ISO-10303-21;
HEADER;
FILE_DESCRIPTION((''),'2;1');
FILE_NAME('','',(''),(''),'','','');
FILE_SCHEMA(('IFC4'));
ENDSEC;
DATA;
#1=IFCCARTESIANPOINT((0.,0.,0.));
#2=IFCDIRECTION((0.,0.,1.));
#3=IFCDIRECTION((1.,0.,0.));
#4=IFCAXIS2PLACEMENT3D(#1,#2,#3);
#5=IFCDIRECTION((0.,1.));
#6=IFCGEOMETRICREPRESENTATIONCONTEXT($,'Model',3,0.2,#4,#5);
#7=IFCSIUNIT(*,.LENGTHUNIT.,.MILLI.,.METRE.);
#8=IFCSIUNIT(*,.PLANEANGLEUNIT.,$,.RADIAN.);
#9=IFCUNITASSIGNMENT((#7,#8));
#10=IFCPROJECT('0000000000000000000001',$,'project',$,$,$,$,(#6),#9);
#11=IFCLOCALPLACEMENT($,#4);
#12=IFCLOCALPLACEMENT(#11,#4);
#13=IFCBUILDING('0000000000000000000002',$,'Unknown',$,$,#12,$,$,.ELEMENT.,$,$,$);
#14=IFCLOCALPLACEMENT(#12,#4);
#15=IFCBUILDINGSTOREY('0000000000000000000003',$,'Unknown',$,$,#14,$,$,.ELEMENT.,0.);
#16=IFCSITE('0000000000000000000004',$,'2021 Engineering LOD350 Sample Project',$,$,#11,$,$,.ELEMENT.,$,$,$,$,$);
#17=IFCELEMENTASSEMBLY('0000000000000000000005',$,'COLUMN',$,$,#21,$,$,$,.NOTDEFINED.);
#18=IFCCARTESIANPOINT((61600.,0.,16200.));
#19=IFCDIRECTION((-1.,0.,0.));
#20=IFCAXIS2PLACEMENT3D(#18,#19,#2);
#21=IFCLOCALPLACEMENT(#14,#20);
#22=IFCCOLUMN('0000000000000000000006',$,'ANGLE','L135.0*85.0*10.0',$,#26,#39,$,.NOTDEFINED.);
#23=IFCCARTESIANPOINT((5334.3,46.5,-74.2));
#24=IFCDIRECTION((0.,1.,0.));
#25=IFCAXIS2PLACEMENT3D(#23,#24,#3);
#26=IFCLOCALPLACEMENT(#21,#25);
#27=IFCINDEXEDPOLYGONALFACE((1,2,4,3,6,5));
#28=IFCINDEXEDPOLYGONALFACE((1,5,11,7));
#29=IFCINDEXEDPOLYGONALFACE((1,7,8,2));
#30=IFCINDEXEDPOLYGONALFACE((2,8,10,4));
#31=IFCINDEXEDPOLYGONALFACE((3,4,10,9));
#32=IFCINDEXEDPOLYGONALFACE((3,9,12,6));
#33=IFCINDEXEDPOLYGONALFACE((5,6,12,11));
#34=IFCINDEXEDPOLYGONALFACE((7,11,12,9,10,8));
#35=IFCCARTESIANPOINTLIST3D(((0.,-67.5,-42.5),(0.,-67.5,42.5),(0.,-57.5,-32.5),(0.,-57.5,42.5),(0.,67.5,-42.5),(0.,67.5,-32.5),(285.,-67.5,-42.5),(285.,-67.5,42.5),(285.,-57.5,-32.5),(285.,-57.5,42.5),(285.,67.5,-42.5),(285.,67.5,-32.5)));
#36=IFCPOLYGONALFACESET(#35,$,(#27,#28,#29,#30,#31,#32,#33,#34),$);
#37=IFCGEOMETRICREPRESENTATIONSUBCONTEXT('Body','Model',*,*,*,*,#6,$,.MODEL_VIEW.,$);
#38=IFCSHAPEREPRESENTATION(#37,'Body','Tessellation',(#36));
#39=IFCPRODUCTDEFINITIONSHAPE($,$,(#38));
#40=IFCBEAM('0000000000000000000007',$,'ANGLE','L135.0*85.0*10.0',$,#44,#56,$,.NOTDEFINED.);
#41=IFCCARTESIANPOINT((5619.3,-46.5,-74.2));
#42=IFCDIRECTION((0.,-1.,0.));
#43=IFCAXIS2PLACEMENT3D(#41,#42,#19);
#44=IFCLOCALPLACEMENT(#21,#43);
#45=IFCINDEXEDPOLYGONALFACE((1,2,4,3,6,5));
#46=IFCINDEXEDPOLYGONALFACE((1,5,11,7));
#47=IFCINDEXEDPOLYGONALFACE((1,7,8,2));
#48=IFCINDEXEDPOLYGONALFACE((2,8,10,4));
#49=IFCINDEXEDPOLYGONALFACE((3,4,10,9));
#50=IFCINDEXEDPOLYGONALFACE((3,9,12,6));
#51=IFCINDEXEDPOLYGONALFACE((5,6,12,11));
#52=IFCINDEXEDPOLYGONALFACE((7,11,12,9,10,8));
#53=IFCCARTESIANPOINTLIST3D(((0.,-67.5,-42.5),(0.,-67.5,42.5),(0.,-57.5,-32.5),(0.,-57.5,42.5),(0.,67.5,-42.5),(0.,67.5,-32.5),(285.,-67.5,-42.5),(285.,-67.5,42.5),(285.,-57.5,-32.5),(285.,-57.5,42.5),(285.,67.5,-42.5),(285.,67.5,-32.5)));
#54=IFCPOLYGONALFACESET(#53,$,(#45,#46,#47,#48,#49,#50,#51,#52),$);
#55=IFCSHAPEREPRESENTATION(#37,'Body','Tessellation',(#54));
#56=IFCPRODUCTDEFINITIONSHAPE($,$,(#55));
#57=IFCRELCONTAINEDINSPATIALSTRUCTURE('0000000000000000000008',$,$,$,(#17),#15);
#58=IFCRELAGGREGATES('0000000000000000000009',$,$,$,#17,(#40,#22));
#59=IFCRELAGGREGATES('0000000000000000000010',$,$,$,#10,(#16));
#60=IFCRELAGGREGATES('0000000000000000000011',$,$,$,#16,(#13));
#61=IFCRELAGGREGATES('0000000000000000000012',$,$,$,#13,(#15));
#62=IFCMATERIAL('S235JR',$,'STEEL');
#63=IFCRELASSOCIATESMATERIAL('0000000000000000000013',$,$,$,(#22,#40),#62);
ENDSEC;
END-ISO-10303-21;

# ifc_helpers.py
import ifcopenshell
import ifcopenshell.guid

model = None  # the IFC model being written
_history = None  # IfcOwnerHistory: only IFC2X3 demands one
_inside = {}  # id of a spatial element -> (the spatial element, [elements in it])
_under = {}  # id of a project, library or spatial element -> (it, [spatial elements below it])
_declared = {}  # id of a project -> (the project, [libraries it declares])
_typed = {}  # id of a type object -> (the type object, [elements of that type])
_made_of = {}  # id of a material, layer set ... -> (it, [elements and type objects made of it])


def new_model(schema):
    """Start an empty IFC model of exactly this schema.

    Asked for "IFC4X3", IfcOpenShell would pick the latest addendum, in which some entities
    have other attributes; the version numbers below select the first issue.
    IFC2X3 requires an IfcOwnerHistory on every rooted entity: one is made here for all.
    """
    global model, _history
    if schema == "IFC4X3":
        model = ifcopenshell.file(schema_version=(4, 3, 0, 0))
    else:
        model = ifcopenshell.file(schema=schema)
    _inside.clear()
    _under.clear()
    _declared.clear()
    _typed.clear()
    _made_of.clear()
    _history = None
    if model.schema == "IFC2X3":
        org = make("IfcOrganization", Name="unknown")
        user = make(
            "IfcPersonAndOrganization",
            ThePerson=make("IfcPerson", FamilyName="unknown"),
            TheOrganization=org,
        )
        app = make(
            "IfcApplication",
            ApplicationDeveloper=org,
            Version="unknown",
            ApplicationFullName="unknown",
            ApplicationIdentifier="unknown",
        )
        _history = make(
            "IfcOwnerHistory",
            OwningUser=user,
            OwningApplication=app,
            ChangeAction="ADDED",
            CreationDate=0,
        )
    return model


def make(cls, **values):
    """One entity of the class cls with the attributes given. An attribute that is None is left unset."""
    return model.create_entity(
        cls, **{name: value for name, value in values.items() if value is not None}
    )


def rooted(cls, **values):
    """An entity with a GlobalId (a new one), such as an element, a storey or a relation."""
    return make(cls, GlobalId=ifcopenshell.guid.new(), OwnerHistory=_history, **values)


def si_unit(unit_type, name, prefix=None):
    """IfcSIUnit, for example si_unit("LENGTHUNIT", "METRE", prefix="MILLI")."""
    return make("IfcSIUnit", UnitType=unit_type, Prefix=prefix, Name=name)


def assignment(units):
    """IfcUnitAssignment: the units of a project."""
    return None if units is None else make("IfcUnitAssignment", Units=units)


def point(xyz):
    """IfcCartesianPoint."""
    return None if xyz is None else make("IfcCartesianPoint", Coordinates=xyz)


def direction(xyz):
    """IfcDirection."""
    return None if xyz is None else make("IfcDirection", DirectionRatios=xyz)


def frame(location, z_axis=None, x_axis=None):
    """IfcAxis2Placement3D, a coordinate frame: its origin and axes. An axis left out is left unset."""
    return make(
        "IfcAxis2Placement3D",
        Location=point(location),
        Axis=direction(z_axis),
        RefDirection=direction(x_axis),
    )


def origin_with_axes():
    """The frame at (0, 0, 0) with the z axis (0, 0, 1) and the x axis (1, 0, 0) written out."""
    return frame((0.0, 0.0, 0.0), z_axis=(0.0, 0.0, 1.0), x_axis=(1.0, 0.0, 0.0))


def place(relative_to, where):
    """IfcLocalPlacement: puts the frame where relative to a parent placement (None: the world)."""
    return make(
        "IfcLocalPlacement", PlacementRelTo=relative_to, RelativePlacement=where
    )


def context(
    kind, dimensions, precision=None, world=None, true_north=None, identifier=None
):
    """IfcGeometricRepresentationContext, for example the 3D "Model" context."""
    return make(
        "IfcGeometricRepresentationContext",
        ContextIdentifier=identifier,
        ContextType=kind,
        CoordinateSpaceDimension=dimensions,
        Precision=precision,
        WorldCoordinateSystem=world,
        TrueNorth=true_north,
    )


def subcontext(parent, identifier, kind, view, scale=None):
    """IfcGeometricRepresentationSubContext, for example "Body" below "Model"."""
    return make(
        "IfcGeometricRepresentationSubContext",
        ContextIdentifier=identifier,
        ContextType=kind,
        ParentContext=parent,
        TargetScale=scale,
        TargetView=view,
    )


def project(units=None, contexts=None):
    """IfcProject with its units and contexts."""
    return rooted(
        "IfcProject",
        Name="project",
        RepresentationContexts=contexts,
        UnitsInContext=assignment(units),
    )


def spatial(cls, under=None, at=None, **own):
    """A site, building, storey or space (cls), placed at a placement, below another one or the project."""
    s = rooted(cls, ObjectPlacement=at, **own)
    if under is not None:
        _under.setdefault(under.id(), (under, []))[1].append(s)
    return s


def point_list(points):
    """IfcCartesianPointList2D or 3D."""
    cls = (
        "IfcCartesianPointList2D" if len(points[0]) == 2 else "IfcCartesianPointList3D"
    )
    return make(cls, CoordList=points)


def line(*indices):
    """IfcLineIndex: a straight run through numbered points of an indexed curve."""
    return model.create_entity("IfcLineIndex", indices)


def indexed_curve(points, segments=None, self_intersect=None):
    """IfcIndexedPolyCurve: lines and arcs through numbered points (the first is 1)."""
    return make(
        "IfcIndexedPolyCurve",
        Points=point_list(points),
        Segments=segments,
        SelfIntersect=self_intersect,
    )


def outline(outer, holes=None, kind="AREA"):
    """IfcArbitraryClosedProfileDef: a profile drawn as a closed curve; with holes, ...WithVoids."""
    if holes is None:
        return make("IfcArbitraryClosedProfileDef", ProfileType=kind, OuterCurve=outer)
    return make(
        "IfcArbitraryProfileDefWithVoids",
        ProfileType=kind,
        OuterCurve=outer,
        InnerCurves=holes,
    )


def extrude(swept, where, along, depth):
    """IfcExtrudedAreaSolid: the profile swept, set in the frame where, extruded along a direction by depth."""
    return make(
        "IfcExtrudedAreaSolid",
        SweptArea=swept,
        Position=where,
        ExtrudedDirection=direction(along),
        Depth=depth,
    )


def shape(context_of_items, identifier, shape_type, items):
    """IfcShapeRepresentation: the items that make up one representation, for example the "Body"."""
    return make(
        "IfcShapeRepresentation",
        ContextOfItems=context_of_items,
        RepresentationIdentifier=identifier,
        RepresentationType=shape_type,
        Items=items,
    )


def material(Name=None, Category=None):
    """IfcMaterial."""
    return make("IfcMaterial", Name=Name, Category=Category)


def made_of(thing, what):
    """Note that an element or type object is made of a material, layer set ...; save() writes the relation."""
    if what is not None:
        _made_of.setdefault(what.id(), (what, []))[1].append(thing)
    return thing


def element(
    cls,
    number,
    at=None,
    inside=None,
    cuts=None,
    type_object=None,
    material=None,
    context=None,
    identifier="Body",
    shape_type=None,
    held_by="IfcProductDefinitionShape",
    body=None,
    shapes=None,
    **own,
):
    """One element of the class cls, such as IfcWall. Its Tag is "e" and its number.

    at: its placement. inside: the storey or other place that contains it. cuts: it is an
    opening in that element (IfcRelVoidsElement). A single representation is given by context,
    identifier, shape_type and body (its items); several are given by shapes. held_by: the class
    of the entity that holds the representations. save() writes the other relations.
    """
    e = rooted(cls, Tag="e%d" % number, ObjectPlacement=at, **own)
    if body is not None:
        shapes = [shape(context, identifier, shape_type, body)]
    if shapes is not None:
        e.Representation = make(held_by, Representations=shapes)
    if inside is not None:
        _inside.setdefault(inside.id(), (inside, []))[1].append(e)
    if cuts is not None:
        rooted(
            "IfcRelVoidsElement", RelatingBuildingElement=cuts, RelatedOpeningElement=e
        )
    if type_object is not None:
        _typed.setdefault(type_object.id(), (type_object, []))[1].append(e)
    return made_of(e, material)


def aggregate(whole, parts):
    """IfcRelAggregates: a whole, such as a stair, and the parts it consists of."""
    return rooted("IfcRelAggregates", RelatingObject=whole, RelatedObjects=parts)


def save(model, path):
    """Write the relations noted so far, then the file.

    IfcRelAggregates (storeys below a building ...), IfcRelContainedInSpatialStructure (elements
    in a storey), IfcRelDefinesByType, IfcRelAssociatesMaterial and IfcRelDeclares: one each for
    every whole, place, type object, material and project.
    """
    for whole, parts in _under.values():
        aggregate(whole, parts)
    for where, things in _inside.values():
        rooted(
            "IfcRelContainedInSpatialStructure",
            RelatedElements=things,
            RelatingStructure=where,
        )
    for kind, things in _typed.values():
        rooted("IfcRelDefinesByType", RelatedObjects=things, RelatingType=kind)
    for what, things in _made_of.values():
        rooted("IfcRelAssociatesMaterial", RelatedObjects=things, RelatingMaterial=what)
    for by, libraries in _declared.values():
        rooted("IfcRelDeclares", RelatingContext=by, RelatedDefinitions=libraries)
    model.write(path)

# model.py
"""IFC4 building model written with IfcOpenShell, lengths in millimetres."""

from ifc_helpers import new_model, si_unit, direction, frame, origin_with_axes, place, context, subcontext, project, spatial, line, indexed_curve, outline, extrude, material, element, aggregate, save


model = new_model("IFC4")

# Units and contexts
model_context = context("Model", 3, precision=0.2, world=origin_with_axes(), true_north=direction((0.0, 1.0)))
body_context = subcontext(model_context, "Body", "Model", "MODEL_VIEW")
ifc_project = project(units=[si_unit("LENGTHUNIT", "METRE", prefix="MILLI"), si_unit("PLANEANGLEUNIT", "RADIAN")], contexts=[model_context])

# Site, building, storey
site_placement = place(None, origin_with_axes())
site = spatial("IfcSite", under=ifc_project, at=site_placement, Name="2021 Engineering LOD350 Sample Project", CompositionType="ELEMENT")
building_placement = place(site_placement, origin_with_axes())
building = spatial("IfcBuilding", under=site, at=building_placement, Name="Unknown", CompositionType="ELEMENT")
storey_placement = place(building_placement, origin_with_axes())
storey = spatial("IfcBuildingStorey", under=building, at=storey_placement, Name="Unknown", CompositionType="ELEMENT", Elevation=0.0)

# Element assembly, column
assembly_1_placement = place(storey_placement, frame((61600.0, 0.0, 16200.0), z_axis=(-1.0, 0.0, 0.0), x_axis=(0.0, 0.0, 1.0)))
assembly_1 = element("IfcElementAssembly", 1, at=assembly_1_placement, inside=storey, Name="COLUMN", PredefinedType="NOTDEFINED")
ifc_material_1 = material(Name="S235JR", Category="STEEL")
column_1_placement = place(assembly_1_placement, frame((5334.3, 46.5, -74.2), z_axis=(0.0, 1.0, 0.0), x_axis=(1.0, 0.0, 0.0)))
column_1 = element("IfcColumn", 2, at=column_1_placement, material=ifc_material_1, Name="ANGLE", Description="L135.0*85.0*10.0", PredefinedType="NOTDEFINED", context=body_context, shape_type="SolidModel", body=[
    extrude(outline(indexed_curve([(-42.5, -67.5), (42.5, -67.5), (42.5, -57.5), (-32.5, -57.5), (-32.5, 67.5), (-42.5, 67.5)], segments=[line(1, 2, 3, 4, 5, 6, 1)])), frame((0.0, 0.0, 0.0), z_axis=(-1.0, 0.0, 0.0), x_axis=(0.0, 0.0, 1.0)), (0.0, 0.0, -1.0), 285.0),
])

# Beam
beam_1_placement = place(assembly_1_placement, frame((5619.3, -46.5, -74.2), z_axis=(0.0, -1.0, 0.0), x_axis=(-1.0, 0.0, 0.0)))
beam_1 = element("IfcBeam", 3, at=beam_1_placement, material=ifc_material_1, Name="ANGLE", Description="L135.0*85.0*10.0", PredefinedType="NOTDEFINED", context=body_context, shape_type="SolidModel", body=[
    extrude(outline(indexed_curve([(-42.5, -67.5), (42.5, -67.5), (42.5, -57.5), (-32.5, -57.5), (-32.5, 67.5), (-42.5, 67.5)], segments=[line(1, 2, 3, 4, 5, 6, 1)])), frame((0.0, 0.0, 0.0), z_axis=(-1.0, 0.0, 0.0), x_axis=(0.0, 0.0, 1.0)), (0.0, 0.0, -1.0), 285.0),
])

aggregate(assembly_1, [beam_1, column_1])

save(model, "model.ifc")
